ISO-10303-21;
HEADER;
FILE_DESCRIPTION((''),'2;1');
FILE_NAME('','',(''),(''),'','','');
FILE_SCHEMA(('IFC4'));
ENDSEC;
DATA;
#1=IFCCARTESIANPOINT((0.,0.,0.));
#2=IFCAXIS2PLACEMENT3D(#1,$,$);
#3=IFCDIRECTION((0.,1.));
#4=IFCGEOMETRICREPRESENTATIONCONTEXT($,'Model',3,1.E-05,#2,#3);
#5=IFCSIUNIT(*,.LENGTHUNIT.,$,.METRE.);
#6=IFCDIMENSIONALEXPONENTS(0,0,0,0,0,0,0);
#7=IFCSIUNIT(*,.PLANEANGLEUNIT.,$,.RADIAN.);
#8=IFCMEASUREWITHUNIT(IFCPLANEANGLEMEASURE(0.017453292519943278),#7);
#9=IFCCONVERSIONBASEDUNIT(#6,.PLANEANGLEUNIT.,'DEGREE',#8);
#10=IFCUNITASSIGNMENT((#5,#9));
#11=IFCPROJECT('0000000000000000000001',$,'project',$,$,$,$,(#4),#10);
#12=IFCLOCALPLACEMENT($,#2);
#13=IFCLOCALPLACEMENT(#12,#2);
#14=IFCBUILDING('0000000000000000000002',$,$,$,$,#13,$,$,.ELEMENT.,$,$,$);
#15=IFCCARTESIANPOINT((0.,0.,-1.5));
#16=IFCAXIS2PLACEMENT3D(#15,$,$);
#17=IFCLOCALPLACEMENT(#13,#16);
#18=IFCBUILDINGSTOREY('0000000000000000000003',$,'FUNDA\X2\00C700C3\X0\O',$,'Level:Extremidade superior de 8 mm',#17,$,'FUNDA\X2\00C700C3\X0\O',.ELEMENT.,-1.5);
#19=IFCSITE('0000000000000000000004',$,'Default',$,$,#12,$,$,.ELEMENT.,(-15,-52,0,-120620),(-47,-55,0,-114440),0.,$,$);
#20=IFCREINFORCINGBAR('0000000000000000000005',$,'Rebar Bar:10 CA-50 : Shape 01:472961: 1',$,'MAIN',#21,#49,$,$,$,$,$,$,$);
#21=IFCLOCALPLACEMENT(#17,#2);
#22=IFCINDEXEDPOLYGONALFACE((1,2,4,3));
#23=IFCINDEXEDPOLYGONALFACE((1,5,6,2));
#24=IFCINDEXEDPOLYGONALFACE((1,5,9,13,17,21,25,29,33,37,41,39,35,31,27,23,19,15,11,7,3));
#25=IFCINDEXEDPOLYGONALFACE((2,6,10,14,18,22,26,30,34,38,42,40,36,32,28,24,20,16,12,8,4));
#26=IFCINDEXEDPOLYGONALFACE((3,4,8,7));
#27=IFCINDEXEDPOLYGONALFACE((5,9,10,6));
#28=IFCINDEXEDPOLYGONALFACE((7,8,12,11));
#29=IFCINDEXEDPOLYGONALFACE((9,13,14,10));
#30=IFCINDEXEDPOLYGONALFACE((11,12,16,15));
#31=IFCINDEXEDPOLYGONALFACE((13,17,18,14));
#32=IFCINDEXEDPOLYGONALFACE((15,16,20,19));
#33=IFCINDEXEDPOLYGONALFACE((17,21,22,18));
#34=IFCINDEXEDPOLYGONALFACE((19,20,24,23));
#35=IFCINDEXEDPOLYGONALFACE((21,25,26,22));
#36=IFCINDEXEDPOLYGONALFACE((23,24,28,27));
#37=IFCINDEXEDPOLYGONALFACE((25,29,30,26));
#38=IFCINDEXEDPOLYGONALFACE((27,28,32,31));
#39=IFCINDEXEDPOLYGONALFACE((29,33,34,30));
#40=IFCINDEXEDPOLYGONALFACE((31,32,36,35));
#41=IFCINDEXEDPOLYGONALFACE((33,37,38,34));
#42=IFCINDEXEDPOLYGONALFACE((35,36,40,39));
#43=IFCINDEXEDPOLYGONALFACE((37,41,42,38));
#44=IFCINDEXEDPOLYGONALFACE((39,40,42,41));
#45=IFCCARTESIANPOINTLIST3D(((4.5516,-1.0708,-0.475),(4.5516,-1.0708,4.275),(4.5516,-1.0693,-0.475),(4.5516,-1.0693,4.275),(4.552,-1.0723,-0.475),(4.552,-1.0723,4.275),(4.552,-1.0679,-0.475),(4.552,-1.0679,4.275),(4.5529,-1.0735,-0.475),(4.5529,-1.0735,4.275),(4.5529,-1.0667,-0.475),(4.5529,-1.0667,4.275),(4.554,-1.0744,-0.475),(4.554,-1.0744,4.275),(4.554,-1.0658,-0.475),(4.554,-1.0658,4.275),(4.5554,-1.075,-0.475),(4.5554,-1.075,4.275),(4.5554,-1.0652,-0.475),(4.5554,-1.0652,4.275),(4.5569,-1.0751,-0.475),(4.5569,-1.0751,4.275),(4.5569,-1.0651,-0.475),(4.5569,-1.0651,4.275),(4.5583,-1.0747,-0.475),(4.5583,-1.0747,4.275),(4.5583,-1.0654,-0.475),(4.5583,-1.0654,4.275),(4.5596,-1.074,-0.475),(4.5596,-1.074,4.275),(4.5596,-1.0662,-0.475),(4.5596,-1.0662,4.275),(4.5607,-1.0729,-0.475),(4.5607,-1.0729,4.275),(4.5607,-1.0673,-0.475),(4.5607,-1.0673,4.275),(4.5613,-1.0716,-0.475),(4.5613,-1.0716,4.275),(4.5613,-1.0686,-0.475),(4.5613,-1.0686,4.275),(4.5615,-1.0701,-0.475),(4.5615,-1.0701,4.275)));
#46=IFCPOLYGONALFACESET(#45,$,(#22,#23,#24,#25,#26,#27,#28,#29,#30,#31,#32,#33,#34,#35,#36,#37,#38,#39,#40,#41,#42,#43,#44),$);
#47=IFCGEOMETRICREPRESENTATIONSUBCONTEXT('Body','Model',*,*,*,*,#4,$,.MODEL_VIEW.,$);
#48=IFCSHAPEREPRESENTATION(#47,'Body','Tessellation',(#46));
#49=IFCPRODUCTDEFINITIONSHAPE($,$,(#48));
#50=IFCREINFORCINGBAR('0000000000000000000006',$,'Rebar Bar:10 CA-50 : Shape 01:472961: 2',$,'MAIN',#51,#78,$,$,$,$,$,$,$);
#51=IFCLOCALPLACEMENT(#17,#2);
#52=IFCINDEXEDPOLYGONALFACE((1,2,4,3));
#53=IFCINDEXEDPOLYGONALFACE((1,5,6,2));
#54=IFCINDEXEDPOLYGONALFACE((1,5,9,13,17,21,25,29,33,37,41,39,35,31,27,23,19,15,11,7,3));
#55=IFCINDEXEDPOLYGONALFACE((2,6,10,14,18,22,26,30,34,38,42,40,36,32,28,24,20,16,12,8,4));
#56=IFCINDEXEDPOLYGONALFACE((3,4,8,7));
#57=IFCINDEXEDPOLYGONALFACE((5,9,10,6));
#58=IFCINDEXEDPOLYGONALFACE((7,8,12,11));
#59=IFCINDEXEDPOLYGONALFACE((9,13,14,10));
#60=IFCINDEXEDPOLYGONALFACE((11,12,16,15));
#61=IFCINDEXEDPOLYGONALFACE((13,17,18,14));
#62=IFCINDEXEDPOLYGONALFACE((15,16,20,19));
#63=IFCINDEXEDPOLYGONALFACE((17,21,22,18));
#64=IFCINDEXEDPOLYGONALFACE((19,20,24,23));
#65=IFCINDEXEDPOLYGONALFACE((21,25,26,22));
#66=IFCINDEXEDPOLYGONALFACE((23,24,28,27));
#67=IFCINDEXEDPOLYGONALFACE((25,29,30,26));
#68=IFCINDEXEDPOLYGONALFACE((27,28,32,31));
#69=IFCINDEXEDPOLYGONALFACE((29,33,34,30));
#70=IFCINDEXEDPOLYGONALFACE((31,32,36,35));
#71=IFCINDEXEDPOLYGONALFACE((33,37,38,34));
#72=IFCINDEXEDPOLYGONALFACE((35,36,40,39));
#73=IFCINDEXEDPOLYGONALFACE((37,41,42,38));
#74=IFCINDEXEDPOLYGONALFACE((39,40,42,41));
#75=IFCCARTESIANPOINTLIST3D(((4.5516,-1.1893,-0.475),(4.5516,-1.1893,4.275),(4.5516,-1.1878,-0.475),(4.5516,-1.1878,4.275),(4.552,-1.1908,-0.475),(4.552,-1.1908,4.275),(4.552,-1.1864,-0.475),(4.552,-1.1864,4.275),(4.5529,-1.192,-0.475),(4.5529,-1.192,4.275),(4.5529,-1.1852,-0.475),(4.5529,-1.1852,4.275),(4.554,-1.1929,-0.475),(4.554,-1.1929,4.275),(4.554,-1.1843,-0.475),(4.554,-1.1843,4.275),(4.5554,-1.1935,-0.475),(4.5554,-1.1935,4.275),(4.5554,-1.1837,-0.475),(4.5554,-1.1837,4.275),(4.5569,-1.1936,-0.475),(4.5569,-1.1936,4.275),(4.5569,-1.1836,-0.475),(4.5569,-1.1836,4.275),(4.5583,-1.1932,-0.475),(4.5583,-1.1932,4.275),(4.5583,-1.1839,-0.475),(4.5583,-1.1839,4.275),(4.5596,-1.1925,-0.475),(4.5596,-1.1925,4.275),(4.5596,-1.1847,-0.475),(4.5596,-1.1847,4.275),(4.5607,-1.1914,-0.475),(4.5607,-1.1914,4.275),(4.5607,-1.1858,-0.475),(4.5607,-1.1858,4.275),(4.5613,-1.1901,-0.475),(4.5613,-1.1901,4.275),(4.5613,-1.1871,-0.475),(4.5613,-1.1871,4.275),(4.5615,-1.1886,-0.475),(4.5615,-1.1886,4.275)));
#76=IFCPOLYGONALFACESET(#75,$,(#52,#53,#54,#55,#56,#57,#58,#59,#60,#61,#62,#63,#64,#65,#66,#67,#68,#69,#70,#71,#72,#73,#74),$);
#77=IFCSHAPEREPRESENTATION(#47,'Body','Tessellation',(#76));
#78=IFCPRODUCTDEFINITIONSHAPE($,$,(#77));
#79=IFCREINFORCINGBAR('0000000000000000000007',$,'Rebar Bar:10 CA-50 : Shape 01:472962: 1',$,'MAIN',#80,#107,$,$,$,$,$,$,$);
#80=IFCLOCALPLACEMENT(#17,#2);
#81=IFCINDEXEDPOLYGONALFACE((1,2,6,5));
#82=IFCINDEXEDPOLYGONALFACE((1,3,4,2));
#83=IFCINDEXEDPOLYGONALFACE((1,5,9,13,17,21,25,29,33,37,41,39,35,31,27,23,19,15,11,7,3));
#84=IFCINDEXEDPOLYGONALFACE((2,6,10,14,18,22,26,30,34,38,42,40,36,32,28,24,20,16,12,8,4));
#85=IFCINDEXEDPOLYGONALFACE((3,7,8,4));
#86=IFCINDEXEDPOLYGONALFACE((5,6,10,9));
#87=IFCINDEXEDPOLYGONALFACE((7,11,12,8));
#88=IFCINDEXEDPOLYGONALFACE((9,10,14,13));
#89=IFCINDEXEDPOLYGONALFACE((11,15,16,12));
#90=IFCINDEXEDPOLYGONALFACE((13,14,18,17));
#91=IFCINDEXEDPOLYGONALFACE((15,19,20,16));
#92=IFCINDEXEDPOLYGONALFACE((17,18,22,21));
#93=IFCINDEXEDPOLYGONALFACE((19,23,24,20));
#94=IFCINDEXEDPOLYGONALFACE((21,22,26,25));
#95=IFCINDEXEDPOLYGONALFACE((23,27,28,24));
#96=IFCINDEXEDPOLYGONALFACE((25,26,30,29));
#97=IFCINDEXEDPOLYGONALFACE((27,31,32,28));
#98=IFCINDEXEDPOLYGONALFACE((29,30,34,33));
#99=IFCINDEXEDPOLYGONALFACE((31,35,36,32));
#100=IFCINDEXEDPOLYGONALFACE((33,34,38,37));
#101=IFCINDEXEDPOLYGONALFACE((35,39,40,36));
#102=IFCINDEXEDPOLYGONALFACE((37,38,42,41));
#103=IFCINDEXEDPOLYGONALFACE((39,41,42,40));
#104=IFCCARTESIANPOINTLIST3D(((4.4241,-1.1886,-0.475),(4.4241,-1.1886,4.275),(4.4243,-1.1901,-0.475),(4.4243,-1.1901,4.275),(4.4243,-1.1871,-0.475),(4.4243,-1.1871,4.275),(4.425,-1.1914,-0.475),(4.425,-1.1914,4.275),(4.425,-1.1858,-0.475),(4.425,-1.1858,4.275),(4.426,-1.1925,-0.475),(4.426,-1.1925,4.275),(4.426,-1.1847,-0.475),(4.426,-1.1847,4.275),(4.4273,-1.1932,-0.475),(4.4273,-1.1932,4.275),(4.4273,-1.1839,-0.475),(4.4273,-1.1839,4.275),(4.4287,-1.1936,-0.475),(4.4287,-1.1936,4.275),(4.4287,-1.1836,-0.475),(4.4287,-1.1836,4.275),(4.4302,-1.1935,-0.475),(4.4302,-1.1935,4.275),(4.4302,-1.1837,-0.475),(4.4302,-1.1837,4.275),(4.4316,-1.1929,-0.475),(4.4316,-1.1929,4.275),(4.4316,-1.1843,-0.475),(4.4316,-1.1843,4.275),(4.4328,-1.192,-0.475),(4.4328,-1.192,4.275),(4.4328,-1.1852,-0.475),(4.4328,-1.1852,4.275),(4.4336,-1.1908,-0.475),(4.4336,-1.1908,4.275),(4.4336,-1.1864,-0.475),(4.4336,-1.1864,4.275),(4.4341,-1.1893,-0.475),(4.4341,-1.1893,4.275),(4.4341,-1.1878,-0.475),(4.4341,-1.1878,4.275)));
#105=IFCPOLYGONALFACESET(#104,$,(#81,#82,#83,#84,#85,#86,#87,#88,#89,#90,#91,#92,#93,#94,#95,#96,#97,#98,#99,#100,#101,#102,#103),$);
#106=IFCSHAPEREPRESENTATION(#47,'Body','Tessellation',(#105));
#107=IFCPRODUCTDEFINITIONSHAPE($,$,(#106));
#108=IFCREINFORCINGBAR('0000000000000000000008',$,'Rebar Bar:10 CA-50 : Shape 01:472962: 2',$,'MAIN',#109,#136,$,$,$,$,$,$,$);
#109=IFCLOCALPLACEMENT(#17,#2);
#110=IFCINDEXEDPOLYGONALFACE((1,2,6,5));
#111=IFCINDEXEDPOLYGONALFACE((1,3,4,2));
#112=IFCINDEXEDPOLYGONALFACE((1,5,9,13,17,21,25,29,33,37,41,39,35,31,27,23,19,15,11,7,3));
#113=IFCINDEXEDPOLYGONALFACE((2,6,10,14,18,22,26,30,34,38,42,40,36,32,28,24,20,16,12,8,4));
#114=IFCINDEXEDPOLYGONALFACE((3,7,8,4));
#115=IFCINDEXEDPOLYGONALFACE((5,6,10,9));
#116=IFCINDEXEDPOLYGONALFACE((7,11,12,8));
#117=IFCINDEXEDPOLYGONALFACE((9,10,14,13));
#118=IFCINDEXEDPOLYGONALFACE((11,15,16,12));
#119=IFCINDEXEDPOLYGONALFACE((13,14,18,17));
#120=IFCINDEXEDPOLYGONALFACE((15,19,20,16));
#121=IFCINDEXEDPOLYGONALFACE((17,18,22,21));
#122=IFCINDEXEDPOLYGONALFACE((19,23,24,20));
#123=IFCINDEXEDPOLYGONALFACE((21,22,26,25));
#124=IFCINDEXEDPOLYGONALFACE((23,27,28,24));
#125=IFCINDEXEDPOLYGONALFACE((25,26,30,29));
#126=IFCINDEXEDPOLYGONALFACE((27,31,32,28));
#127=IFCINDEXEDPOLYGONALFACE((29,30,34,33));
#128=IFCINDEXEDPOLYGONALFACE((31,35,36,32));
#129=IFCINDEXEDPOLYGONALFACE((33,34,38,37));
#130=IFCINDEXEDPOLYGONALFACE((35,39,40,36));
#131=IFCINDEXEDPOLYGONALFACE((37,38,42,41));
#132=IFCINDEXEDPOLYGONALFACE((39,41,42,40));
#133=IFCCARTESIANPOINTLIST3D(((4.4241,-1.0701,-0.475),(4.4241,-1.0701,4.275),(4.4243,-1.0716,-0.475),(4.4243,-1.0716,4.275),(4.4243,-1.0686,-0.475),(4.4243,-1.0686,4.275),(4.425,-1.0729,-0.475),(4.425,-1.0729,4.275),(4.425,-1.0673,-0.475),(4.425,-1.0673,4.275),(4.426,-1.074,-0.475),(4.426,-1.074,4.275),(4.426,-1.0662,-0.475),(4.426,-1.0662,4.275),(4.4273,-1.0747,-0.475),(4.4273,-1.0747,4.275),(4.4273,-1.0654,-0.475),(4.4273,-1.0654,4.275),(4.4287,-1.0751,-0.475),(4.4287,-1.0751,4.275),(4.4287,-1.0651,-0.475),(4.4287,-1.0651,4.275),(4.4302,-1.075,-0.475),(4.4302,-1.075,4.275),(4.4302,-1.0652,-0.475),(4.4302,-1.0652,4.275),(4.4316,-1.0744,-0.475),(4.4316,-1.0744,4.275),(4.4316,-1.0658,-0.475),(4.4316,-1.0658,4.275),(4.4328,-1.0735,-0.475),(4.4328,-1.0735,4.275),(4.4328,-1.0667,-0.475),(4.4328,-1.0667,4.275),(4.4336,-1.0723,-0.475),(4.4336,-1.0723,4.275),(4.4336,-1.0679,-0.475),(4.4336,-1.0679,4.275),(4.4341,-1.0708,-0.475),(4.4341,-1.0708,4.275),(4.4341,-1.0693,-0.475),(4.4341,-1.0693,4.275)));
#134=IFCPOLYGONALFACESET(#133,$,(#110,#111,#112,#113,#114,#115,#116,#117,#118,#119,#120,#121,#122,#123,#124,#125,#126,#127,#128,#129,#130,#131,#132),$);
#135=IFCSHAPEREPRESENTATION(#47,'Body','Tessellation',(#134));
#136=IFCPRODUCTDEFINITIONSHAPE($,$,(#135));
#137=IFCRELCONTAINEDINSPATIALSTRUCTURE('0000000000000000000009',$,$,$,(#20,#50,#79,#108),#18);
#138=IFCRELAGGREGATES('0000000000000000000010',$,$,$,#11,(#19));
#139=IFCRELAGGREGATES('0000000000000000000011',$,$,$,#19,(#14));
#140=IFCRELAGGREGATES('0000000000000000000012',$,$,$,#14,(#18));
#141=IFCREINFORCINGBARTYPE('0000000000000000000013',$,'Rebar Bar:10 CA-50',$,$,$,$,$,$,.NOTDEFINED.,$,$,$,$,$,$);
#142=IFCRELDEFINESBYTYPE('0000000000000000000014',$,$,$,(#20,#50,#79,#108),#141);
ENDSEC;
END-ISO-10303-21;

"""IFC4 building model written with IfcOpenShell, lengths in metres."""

from ifc_helpers import new_model, entity, si_unit, converted_unit, direction, frame, origin, place, context, subcontext, project, spatial, type_object, element, save


model = new_model("IFC4")

# Units and contexts
model_context = context("Model", 3, precision=1e-05, world=origin(), true_north=direction((0.0, 1.0)))
body_context = subcontext(model_context, "Body", "Model", "MODEL_VIEW")
ifc_project = project(units=[si_unit("LENGTHUNIT", "METRE"), converted_unit("PLANEANGLEUNIT", "DEGREE", entity("IfcPlaneAngleMeasure", 0.017453292519943278), si_unit("PLANEANGLEUNIT", "RADIAN"), dimensions=[0, 0, 0, 0, 0, 0, 0])], contexts=[model_context])

# Site, building, storey
site_placement = place(None, origin())
site = spatial("IfcSite", under=ifc_project, at=site_placement, Name="Default", CompositionType="ELEMENT", RefLatitude=(-15, -52, 0, -120620), RefLongitude=(-47, -55, 0, -114440), RefElevation=0.0)
building_placement = place(site_placement, origin())
building = spatial("IfcBuilding", under=site, at=building_placement, CompositionType="ELEMENT")
storey_placement = place(building_placement, frame((0.0, 0.0, -1.5)))
storey = spatial("IfcBuildingStorey", under=building, at=storey_placement, Name="FUNDAÇÃO", ObjectType="Level:Extremidade superior de 8 mm", LongName="FUNDAÇÃO", CompositionType="ELEMENT", Elevation=-1.5)

# Reinforcing bars
reinforcing_bar_type_1 = type_object("IfcReinforcingBarType", Name="Rebar Bar:10 CA-50", PredefinedType="NOTDEFINED")
reinforcing_bar_1_placement = place(storey_placement, origin())
element("IfcReinforcingBar", 1, at=reinforcing_bar_1_placement, inside=storey, type_object=reinforcing_bar_type_1, Name="Rebar Bar:10 CA-50 : Shape 01:472961: 1", ObjectType="MAIN", context=body_context, shape_type="AdvancedSweptSolid", body=[
    entity("IfcSweptDiskSolid", entity("IfcIndexedPolyCurve", entity("IfcCartesianPointList3D", [[4.5565, -1.0701, -0.475], [4.5565, -1.0701, 4.275]]), None, False), 0.005, None, 0.0, 1.0),
])
reinforcing_bar_2_placement = place(storey_placement, origin())
element("IfcReinforcingBar", 2, at=reinforcing_bar_2_placement, inside=storey, type_object=reinforcing_bar_type_1, Name="Rebar Bar:10 CA-50 : Shape 01:472961: 2", ObjectType="MAIN", context=body_context, shape_type="AdvancedSweptSolid", body=[
    entity("IfcSweptDiskSolid", entity("IfcIndexedPolyCurve", entity("IfcCartesianPointList3D", [[4.5565, -1.1886, -0.475], [4.5565, -1.1886, 4.275]]), None, False), 0.005, None, 0.0, 1.0),
])
reinforcing_bar_3_placement = place(storey_placement, origin())
element("IfcReinforcingBar", 3, at=reinforcing_bar_3_placement, inside=storey, type_object=reinforcing_bar_type_1, Name="Rebar Bar:10 CA-50 : Shape 01:472962: 1", ObjectType="MAIN", context=body_context, shape_type="AdvancedSweptSolid", body=[
    entity("IfcSweptDiskSolid", entity("IfcIndexedPolyCurve", entity("IfcCartesianPointList3D", [[4.4291, -1.1886, 4.275], [4.4291, -1.1886, -0.475]]), None, False), 0.005, None, 0.0, 1.0),
])
reinforcing_bar_4_placement = place(storey_placement, origin())
element("IfcReinforcingBar", 4, at=reinforcing_bar_4_placement, inside=storey, type_object=reinforcing_bar_type_1, Name="Rebar Bar:10 CA-50 : Shape 01:472962: 2", ObjectType="MAIN", context=body_context, shape_type="AdvancedSweptSolid", body=[
    entity("IfcSweptDiskSolid", entity("IfcIndexedPolyCurve", entity("IfcCartesianPointList3D", [[4.4291, -1.0701, 4.275], [4.4291, -1.0701, -0.475]]), None, False), 0.005, None, 0.0, 1.0),
])

save(model, "model.ifc")
